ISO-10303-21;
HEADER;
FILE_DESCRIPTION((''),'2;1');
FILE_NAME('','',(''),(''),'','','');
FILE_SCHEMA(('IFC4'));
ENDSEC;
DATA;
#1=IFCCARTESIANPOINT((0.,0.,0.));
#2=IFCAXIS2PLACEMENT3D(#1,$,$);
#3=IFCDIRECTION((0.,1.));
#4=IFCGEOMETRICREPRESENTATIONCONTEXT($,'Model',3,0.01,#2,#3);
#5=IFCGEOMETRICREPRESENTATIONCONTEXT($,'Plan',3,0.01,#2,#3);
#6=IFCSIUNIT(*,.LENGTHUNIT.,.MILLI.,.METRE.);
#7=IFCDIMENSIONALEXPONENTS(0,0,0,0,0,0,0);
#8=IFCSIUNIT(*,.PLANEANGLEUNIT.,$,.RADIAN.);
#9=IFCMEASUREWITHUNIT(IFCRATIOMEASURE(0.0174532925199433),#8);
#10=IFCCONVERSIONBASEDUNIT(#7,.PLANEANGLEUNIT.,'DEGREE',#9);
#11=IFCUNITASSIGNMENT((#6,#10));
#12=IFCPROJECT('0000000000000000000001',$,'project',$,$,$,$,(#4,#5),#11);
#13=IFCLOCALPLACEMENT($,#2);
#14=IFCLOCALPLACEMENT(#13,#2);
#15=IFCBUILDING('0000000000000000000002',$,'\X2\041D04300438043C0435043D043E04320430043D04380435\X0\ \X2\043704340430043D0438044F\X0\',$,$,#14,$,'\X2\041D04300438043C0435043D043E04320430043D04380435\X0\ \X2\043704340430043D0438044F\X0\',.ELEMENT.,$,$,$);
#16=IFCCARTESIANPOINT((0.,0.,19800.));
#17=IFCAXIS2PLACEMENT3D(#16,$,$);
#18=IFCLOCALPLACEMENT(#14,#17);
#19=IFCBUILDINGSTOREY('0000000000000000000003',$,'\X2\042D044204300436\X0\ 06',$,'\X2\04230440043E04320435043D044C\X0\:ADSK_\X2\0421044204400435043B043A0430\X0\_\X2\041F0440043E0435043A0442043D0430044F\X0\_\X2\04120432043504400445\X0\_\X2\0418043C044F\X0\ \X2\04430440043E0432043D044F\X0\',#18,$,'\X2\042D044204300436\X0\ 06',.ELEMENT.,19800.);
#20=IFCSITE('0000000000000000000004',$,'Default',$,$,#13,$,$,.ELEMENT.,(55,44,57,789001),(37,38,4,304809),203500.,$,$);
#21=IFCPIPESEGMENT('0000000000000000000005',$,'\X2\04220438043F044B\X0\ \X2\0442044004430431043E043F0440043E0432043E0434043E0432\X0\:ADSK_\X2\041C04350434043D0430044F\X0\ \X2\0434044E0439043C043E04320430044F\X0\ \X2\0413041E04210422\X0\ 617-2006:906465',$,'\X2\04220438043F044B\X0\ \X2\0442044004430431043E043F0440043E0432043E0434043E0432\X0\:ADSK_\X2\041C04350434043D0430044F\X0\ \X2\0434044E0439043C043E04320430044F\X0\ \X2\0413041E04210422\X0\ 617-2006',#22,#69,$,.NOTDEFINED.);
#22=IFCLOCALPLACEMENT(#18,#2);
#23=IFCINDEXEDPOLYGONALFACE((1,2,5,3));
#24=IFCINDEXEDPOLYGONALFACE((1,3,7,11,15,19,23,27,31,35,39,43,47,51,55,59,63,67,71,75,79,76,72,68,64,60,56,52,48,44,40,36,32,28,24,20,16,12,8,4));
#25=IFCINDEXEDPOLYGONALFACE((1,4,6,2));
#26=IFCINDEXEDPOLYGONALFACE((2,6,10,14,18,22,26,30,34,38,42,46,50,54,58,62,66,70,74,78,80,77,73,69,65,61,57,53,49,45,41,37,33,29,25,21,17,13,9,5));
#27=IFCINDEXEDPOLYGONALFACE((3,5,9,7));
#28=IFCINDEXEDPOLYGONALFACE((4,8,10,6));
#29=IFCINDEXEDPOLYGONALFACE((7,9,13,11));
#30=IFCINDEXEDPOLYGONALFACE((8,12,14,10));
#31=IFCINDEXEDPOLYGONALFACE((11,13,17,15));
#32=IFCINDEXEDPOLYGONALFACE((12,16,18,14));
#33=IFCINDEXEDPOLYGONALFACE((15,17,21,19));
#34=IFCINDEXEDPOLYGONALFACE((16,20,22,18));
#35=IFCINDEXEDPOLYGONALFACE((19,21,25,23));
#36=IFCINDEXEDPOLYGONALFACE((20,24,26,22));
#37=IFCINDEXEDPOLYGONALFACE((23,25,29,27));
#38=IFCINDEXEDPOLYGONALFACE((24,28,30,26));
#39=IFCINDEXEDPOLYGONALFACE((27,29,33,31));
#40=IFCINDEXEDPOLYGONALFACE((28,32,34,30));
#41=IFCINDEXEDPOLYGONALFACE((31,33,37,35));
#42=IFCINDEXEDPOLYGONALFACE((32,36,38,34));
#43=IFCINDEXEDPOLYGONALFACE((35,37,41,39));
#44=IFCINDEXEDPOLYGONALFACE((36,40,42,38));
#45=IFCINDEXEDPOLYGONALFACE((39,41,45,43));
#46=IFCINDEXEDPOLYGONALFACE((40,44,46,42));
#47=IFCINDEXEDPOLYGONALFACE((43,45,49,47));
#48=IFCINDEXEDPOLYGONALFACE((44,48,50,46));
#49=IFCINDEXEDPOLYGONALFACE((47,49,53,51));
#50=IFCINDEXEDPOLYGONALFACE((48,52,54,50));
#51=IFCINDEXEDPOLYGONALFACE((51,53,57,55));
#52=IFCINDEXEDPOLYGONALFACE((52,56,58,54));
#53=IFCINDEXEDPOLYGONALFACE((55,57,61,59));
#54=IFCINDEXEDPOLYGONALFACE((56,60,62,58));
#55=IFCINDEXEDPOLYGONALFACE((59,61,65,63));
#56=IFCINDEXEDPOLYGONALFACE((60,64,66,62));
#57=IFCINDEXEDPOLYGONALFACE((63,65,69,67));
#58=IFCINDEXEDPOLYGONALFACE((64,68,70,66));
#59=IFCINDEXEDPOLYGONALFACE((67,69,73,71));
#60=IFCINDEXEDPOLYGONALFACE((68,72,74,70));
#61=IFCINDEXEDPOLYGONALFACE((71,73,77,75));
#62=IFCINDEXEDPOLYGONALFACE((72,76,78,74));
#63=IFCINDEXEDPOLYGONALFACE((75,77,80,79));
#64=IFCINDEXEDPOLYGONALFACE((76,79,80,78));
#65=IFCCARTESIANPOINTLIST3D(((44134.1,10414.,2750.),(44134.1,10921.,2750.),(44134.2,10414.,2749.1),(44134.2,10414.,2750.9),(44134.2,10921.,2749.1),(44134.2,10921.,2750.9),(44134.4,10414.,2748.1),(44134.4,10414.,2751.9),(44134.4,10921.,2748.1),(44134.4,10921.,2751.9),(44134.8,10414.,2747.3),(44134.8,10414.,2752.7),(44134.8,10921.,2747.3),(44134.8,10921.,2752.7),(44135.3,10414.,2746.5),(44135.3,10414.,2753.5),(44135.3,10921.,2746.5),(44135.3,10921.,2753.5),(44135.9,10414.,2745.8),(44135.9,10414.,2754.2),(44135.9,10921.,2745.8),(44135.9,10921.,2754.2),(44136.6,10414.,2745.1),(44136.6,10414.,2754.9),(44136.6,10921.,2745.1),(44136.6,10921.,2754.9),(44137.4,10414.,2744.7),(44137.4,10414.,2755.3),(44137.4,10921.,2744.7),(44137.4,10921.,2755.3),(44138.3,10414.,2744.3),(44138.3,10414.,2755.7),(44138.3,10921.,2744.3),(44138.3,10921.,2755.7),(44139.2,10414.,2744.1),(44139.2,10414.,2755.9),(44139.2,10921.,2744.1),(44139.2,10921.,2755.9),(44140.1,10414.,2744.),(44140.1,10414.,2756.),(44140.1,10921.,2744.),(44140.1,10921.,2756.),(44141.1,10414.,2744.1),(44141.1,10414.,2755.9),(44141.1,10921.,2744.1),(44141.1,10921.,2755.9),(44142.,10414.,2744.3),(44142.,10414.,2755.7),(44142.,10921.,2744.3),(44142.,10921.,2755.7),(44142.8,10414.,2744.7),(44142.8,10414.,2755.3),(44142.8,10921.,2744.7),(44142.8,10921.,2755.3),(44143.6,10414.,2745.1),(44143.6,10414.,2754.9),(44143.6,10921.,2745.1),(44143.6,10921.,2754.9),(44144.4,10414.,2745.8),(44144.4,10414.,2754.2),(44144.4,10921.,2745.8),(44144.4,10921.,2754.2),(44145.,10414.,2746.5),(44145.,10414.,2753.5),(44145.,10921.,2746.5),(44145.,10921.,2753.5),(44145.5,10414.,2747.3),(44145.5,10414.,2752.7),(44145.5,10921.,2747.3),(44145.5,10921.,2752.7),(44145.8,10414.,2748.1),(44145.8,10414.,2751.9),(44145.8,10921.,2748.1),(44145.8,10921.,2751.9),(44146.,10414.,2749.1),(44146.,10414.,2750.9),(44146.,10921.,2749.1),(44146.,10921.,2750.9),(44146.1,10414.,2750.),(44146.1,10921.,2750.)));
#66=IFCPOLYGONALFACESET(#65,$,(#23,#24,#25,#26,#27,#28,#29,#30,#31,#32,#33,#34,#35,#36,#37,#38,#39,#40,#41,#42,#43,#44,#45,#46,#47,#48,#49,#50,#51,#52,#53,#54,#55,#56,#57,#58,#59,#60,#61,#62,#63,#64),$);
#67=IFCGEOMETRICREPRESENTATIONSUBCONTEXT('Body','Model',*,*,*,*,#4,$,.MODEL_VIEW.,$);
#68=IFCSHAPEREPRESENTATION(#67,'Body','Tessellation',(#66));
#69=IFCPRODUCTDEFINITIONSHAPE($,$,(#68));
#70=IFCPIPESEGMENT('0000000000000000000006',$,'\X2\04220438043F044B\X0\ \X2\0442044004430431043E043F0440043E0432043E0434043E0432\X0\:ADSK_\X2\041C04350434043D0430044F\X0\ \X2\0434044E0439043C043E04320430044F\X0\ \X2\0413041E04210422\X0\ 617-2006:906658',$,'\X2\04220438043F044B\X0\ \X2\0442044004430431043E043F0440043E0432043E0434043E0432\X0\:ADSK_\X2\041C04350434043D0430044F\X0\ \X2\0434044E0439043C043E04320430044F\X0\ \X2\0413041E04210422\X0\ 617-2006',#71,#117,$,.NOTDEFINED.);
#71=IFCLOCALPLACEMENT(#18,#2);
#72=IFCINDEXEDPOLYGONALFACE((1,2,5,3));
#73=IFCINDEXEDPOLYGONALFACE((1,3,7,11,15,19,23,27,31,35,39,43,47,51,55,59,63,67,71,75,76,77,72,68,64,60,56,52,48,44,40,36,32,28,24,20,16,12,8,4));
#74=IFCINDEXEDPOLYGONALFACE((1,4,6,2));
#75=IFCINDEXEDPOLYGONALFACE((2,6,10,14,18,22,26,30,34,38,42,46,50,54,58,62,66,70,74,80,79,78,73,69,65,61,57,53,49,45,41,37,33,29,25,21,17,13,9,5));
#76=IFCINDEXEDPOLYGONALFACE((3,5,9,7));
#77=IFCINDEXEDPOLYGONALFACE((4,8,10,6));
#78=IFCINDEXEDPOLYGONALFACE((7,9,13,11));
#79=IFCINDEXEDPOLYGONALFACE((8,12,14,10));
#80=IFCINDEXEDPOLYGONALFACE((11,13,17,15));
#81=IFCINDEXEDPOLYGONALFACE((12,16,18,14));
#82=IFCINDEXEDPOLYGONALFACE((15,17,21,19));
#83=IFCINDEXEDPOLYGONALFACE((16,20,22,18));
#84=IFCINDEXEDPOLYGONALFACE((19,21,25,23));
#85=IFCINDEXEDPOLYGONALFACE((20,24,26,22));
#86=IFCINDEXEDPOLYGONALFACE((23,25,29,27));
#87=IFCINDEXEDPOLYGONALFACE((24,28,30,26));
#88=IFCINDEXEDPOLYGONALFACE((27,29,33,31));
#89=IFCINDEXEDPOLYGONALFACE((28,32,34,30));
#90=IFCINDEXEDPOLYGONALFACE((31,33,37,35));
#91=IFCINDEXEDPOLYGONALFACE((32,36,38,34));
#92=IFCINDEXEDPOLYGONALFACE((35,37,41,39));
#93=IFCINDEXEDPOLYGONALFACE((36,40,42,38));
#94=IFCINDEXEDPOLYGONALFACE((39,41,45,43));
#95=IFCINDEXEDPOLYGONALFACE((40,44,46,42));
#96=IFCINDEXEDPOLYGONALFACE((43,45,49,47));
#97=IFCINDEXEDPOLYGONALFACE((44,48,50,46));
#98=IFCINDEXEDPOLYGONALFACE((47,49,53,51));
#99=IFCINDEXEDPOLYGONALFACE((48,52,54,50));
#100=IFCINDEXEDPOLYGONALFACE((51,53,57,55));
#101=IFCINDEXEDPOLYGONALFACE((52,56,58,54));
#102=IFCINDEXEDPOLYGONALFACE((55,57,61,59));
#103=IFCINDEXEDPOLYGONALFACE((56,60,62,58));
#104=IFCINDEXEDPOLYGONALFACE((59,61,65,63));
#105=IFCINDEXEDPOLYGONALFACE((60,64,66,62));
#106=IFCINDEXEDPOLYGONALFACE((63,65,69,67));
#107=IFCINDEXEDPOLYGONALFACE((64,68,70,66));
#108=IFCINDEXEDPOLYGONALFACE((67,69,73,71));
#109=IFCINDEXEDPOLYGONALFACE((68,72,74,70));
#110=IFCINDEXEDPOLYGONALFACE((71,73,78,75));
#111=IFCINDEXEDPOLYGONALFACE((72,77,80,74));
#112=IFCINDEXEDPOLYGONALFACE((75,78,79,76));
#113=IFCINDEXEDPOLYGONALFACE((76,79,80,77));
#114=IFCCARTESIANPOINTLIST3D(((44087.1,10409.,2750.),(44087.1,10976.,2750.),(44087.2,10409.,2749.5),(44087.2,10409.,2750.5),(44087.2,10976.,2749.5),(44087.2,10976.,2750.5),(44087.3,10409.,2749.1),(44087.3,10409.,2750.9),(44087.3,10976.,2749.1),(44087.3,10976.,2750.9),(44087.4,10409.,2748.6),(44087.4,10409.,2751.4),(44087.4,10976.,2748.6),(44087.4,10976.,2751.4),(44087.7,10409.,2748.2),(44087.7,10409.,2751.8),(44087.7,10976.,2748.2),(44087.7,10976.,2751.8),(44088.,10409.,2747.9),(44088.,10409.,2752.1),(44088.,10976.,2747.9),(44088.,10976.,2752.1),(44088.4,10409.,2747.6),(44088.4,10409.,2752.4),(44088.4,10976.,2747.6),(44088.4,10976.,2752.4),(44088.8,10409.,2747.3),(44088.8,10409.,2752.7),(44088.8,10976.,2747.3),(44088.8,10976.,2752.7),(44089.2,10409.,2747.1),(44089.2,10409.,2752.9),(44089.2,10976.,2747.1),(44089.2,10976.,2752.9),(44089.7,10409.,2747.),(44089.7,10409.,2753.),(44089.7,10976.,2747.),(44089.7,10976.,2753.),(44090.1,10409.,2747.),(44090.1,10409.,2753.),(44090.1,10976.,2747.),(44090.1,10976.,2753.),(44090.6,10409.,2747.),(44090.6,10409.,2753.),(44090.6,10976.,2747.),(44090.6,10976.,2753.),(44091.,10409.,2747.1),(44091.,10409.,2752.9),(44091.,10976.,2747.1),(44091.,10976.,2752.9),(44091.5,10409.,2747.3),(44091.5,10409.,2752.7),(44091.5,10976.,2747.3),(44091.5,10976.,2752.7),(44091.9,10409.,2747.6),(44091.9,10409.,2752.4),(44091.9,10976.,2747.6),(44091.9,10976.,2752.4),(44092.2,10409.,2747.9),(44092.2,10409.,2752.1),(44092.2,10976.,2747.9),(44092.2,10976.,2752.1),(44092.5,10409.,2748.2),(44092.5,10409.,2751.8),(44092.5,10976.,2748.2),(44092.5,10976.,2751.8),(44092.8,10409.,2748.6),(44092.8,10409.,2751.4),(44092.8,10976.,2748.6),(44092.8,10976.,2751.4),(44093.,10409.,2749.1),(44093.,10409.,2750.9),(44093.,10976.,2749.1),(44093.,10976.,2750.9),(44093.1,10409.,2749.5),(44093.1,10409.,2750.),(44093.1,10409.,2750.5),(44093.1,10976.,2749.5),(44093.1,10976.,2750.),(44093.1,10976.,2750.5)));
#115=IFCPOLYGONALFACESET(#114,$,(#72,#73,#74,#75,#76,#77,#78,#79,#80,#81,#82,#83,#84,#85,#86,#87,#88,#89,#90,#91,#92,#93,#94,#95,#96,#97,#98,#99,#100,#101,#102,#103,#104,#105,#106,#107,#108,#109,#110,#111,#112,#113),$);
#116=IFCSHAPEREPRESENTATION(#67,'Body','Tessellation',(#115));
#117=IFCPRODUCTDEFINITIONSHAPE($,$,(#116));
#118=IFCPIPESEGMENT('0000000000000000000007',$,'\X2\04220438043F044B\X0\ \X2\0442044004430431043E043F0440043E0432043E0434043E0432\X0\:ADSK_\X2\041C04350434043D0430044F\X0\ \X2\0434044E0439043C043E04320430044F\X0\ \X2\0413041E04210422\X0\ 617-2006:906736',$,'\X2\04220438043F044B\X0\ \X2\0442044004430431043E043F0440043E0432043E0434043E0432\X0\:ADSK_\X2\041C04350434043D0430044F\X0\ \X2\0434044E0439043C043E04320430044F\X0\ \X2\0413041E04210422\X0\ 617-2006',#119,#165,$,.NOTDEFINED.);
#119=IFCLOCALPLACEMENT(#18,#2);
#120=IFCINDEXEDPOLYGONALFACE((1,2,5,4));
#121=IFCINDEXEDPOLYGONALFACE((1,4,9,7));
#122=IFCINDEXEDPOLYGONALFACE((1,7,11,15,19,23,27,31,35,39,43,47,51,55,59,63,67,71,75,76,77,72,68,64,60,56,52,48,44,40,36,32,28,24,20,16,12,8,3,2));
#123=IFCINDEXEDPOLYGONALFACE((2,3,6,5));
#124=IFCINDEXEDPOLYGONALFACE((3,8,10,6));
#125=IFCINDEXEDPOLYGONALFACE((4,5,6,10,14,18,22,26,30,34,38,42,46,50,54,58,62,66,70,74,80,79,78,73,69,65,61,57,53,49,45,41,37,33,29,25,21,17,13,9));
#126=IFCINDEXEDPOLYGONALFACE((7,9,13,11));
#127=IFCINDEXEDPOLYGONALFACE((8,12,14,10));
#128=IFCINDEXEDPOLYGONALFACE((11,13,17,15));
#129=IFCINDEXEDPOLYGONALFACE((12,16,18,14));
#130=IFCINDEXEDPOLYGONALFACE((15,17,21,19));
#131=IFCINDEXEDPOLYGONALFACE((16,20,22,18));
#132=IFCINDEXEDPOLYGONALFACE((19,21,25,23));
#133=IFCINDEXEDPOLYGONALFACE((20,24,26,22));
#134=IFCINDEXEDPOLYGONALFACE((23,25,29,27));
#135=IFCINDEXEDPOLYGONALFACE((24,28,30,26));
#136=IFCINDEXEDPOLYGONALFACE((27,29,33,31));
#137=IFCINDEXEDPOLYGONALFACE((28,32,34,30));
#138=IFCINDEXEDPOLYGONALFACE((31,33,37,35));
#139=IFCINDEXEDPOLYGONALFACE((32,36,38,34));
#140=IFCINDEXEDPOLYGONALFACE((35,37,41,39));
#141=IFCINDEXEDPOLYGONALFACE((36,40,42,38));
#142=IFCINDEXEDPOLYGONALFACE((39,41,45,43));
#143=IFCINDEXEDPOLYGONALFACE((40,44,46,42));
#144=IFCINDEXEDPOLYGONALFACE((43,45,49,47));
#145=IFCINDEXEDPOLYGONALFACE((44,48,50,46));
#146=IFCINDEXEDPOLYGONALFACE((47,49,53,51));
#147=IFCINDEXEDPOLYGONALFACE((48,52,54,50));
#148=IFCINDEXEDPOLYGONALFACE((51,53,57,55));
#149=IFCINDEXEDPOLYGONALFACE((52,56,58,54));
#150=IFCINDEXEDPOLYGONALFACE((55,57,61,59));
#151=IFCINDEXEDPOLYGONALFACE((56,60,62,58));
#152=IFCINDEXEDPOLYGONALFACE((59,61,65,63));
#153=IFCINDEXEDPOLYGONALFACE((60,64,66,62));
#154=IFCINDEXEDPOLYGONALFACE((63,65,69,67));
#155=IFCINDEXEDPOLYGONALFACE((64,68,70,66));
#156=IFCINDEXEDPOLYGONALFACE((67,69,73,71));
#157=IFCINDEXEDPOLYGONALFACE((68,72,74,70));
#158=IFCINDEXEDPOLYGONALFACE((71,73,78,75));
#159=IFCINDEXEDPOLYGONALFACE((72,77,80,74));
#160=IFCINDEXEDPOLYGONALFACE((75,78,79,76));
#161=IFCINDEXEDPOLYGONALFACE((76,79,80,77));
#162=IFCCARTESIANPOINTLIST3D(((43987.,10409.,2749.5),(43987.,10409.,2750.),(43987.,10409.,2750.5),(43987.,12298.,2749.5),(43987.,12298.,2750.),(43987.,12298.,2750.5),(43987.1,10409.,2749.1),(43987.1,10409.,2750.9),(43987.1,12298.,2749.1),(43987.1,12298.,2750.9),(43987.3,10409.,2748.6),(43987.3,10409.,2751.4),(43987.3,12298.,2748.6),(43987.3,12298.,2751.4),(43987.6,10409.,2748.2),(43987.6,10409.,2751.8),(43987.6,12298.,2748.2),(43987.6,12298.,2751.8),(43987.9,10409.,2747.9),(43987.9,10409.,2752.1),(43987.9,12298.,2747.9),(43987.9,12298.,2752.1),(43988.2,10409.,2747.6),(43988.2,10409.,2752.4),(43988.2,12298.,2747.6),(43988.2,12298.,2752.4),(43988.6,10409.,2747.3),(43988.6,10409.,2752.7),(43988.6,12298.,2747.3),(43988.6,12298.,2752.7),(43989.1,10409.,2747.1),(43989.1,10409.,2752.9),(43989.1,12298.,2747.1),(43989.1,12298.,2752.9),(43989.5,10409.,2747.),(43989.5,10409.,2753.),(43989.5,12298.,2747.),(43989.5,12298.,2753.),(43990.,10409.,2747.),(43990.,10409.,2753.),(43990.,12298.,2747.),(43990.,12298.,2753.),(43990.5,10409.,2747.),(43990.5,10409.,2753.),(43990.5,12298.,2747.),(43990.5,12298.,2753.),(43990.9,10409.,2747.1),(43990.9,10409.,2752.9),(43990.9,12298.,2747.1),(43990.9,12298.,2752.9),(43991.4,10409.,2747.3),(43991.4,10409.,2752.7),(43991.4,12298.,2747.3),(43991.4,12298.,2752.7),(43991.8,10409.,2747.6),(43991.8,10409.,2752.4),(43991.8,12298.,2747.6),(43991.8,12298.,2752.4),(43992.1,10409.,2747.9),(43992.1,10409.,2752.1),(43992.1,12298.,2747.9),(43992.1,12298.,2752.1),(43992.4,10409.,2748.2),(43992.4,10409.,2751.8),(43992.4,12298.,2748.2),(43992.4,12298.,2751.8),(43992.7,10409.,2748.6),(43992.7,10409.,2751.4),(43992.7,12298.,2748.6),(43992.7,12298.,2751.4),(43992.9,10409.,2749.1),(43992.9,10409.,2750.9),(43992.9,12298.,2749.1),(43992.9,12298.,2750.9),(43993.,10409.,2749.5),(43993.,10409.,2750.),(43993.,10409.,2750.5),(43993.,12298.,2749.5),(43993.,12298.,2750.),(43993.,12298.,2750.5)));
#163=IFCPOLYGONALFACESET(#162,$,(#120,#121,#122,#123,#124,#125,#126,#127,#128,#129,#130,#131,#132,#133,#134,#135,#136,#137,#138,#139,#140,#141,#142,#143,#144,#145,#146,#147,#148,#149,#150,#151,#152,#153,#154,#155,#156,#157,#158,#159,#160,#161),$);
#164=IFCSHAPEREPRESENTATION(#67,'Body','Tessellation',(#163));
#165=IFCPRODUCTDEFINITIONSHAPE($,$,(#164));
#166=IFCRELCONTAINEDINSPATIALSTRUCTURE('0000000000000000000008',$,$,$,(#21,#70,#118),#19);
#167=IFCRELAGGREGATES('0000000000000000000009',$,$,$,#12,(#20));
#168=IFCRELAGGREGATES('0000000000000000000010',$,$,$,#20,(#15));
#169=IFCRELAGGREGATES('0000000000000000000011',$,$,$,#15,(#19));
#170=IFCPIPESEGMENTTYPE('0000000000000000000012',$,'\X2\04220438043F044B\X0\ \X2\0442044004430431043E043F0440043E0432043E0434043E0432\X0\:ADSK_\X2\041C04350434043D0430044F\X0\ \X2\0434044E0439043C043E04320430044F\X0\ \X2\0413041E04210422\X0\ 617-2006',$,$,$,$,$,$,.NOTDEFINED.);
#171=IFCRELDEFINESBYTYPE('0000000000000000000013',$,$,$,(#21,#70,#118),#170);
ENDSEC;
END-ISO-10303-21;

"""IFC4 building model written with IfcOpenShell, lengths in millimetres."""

from ifc_helpers import new_model, entity, si_unit, converted_unit, direction, frame, origin, place, context, subcontext, project, spatial, indexed_curve, outline, extrude, type_object, element, save


model = new_model("IFC4")

# Units and contexts
model_context = context("Model", 3, precision=0.01, world=origin(), true_north=direction((0.0, 1.0)))
plan_context = context("Plan", 3, precision=0.01, world=origin(), true_north=direction((0.0, 1.0)))
body_context = subcontext(model_context, "Body", "Model", "MODEL_VIEW")
ifc_project = project(units=[si_unit("LENGTHUNIT", "METRE", prefix="MILLI"), converted_unit("PLANEANGLEUNIT", "DEGREE", entity("IfcRatioMeasure", 0.0174532925199433), si_unit("PLANEANGLEUNIT", "RADIAN"), dimensions=[0, 0, 0, 0, 0, 0, 0])], contexts=[model_context, plan_context])

# Site, building, storey
site_placement = place(None, origin())
site = spatial("IfcSite", under=ifc_project, at=site_placement, Name="Default", CompositionType="ELEMENT", RefLatitude=(55, 44, 57, 789001), RefLongitude=(37, 38, 4, 304809), RefElevation=203500.0)
building_placement = place(site_placement, origin())
building = spatial("IfcBuilding", under=site, at=building_placement, Name="Наименование здания", LongName="Наименование здания", CompositionType="ELEMENT")
storey_placement = place(building_placement, frame((0.0, 0.0, 19800.0)))
storey = spatial("IfcBuildingStorey", under=building, at=storey_placement, Name="Этаж 06", ObjectType="Уровень:ADSK_Стрелка_Проектная_Вверх_Имя уровня", LongName="Этаж 06", CompositionType="ELEMENT", Elevation=19800.0)

# Pipe segments
pipe_segment_type = type_object("IfcPipeSegmentType", Name="Типы трубопроводов:ADSK_Медная дюймовая ГОСТ 617-2006", PredefinedType="NOTDEFINED")
placement = place(storey_placement, origin())
element("IfcPipeSegment", 1, at=placement, inside=storey, type_object=pipe_segment_type, Name="Типы трубопроводов:ADSK_Медная дюймовая ГОСТ 617-2006:906465", ObjectType="Типы трубопроводов:ADSK_Медная дюймовая ГОСТ 617-2006", PredefinedType="NOTDEFINED", context=body_context, shape_type="SweptSolid", body=[
    extrude(outline(indexed_curve([(6.0, 0.0), (5.9, 0.9), (5.7, 1.9), (5.3, 2.7), (4.9, 3.5), (4.2, 4.2), (3.5, 4.9), (2.7, 5.3), (1.9, 5.7), (0.9, 5.9), (0.0, 6.0), (-0.9, 5.9), (-1.9, 5.7), (-2.7, 5.3), (-3.5, 4.9), (-4.2, 4.2), (-4.9, 3.5), (-5.3, 2.7), (-5.7, 1.9), (-5.9, 0.9), (-6.0, 0.0), (-5.9, -0.9), (-5.7, -1.9), (-5.3, -2.7), (-4.9, -3.5), (-4.2, -4.2), (-3.5, -4.9), (-2.7, -5.3), (-1.9, -5.7), (-0.9, -5.9), (0.0, -6.0), (0.9, -5.9), (1.9, -5.7), (2.7, -5.3), (3.5, -4.9), (4.2, -4.2), (4.9, -3.5), (5.3, -2.7), (5.7, -1.9), (5.9, -0.9), (6.0, 0.0)], self_intersect=False)), frame((44140.1, 10414.0, 2750.0), z_axis=(0.0, 1.0, 0.0), x_axis=(1.0, 0.0, 0.0)), (0.0, 0.0, 1.0), 507.0),
])
element("IfcPipeSegment", 2, at=placement, inside=storey, type_object=pipe_segment_type, Name="Типы трубопроводов:ADSK_Медная дюймовая ГОСТ 617-2006:906658", ObjectType="Типы трубопроводов:ADSK_Медная дюймовая ГОСТ 617-2006", PredefinedType="NOTDEFINED", context=body_context, shape_type="SweptSolid", body=[
    extrude(outline(indexed_curve([(3.0, 0.0), (3.0, 0.5), (2.9, 0.9), (2.7, 1.4), (2.4, 1.8), (2.1, 2.1), (1.8, 2.4), (1.4, 2.7), (0.9, 2.9), (0.5, 3.0), (0.0, 3.0), (-0.5, 3.0), (-0.9, 2.9), (-1.4, 2.7), (-1.8, 2.4), (-2.1, 2.1), (-2.4, 1.8), (-2.7, 1.4), (-2.9, 0.9), (-3.0, 0.5), (-3.0, 0.0), (-3.0, -0.5), (-2.9, -0.9), (-2.7, -1.4), (-2.4, -1.8), (-2.1, -2.1), (-1.8, -2.4), (-1.4, -2.7), (-0.9, -2.9), (-0.5, -3.0), (0.0, -3.0), (0.5, -3.0), (0.9, -2.9), (1.4, -2.7), (1.8, -2.4), (2.1, -2.1), (2.4, -1.8), (2.7, -1.4), (2.9, -0.9), (3.0, -0.5), (3.0, 0.0)], self_intersect=False)), frame((44090.1, 10409.0, 2750.0), z_axis=(0.0, 1.0, 0.0), x_axis=(1.0, 0.0, 0.0)), (0.0, 0.0, 1.0), 567.0),
])
element("IfcPipeSegment", 3, at=placement, inside=storey, type_object=pipe_segment_type, Name="Типы трубопроводов:ADSK_Медная дюймовая ГОСТ 617-2006:906736", ObjectType="Типы трубопроводов:ADSK_Медная дюймовая ГОСТ 617-2006", PredefinedType="NOTDEFINED", context=body_context, shape_type="SweptSolid", body=[
    extrude(outline(indexed_curve([(3.0, 0.0), (3.0, 0.5), (2.9, 0.9), (2.7, 1.4), (2.4, 1.8), (2.1, 2.1), (1.8, 2.4), (1.4, 2.7), (0.9, 2.9), (0.5, 3.0), (0.0, 3.0), (-0.5, 3.0), (-0.9, 2.9), (-1.4, 2.7), (-1.8, 2.4), (-2.1, 2.1), (-2.4, 1.8), (-2.7, 1.4), (-2.9, 0.9), (-3.0, 0.5), (-3.0, 0.0), (-3.0, -0.5), (-2.9, -0.9), (-2.7, -1.4), (-2.4, -1.8), (-2.1, -2.1), (-1.8, -2.4), (-1.4, -2.7), (-0.9, -2.9), (-0.5, -3.0), (0.0, -3.0), (0.5, -3.0), (0.9, -2.9), (1.4, -2.7), (1.8, -2.4), (2.1, -2.1), (2.4, -1.8), (2.7, -1.4), (2.9, -0.9), (3.0, -0.5), (3.0, 0.0)], self_intersect=False)), frame((43990.0, 10409.0, 2750.0), z_axis=(0.0, 1.0, 0.0), x_axis=(1.0, 0.0, 0.0)), (0.0, 0.0, 1.0), 1889.0),
])

save(model, "model.ifc")
